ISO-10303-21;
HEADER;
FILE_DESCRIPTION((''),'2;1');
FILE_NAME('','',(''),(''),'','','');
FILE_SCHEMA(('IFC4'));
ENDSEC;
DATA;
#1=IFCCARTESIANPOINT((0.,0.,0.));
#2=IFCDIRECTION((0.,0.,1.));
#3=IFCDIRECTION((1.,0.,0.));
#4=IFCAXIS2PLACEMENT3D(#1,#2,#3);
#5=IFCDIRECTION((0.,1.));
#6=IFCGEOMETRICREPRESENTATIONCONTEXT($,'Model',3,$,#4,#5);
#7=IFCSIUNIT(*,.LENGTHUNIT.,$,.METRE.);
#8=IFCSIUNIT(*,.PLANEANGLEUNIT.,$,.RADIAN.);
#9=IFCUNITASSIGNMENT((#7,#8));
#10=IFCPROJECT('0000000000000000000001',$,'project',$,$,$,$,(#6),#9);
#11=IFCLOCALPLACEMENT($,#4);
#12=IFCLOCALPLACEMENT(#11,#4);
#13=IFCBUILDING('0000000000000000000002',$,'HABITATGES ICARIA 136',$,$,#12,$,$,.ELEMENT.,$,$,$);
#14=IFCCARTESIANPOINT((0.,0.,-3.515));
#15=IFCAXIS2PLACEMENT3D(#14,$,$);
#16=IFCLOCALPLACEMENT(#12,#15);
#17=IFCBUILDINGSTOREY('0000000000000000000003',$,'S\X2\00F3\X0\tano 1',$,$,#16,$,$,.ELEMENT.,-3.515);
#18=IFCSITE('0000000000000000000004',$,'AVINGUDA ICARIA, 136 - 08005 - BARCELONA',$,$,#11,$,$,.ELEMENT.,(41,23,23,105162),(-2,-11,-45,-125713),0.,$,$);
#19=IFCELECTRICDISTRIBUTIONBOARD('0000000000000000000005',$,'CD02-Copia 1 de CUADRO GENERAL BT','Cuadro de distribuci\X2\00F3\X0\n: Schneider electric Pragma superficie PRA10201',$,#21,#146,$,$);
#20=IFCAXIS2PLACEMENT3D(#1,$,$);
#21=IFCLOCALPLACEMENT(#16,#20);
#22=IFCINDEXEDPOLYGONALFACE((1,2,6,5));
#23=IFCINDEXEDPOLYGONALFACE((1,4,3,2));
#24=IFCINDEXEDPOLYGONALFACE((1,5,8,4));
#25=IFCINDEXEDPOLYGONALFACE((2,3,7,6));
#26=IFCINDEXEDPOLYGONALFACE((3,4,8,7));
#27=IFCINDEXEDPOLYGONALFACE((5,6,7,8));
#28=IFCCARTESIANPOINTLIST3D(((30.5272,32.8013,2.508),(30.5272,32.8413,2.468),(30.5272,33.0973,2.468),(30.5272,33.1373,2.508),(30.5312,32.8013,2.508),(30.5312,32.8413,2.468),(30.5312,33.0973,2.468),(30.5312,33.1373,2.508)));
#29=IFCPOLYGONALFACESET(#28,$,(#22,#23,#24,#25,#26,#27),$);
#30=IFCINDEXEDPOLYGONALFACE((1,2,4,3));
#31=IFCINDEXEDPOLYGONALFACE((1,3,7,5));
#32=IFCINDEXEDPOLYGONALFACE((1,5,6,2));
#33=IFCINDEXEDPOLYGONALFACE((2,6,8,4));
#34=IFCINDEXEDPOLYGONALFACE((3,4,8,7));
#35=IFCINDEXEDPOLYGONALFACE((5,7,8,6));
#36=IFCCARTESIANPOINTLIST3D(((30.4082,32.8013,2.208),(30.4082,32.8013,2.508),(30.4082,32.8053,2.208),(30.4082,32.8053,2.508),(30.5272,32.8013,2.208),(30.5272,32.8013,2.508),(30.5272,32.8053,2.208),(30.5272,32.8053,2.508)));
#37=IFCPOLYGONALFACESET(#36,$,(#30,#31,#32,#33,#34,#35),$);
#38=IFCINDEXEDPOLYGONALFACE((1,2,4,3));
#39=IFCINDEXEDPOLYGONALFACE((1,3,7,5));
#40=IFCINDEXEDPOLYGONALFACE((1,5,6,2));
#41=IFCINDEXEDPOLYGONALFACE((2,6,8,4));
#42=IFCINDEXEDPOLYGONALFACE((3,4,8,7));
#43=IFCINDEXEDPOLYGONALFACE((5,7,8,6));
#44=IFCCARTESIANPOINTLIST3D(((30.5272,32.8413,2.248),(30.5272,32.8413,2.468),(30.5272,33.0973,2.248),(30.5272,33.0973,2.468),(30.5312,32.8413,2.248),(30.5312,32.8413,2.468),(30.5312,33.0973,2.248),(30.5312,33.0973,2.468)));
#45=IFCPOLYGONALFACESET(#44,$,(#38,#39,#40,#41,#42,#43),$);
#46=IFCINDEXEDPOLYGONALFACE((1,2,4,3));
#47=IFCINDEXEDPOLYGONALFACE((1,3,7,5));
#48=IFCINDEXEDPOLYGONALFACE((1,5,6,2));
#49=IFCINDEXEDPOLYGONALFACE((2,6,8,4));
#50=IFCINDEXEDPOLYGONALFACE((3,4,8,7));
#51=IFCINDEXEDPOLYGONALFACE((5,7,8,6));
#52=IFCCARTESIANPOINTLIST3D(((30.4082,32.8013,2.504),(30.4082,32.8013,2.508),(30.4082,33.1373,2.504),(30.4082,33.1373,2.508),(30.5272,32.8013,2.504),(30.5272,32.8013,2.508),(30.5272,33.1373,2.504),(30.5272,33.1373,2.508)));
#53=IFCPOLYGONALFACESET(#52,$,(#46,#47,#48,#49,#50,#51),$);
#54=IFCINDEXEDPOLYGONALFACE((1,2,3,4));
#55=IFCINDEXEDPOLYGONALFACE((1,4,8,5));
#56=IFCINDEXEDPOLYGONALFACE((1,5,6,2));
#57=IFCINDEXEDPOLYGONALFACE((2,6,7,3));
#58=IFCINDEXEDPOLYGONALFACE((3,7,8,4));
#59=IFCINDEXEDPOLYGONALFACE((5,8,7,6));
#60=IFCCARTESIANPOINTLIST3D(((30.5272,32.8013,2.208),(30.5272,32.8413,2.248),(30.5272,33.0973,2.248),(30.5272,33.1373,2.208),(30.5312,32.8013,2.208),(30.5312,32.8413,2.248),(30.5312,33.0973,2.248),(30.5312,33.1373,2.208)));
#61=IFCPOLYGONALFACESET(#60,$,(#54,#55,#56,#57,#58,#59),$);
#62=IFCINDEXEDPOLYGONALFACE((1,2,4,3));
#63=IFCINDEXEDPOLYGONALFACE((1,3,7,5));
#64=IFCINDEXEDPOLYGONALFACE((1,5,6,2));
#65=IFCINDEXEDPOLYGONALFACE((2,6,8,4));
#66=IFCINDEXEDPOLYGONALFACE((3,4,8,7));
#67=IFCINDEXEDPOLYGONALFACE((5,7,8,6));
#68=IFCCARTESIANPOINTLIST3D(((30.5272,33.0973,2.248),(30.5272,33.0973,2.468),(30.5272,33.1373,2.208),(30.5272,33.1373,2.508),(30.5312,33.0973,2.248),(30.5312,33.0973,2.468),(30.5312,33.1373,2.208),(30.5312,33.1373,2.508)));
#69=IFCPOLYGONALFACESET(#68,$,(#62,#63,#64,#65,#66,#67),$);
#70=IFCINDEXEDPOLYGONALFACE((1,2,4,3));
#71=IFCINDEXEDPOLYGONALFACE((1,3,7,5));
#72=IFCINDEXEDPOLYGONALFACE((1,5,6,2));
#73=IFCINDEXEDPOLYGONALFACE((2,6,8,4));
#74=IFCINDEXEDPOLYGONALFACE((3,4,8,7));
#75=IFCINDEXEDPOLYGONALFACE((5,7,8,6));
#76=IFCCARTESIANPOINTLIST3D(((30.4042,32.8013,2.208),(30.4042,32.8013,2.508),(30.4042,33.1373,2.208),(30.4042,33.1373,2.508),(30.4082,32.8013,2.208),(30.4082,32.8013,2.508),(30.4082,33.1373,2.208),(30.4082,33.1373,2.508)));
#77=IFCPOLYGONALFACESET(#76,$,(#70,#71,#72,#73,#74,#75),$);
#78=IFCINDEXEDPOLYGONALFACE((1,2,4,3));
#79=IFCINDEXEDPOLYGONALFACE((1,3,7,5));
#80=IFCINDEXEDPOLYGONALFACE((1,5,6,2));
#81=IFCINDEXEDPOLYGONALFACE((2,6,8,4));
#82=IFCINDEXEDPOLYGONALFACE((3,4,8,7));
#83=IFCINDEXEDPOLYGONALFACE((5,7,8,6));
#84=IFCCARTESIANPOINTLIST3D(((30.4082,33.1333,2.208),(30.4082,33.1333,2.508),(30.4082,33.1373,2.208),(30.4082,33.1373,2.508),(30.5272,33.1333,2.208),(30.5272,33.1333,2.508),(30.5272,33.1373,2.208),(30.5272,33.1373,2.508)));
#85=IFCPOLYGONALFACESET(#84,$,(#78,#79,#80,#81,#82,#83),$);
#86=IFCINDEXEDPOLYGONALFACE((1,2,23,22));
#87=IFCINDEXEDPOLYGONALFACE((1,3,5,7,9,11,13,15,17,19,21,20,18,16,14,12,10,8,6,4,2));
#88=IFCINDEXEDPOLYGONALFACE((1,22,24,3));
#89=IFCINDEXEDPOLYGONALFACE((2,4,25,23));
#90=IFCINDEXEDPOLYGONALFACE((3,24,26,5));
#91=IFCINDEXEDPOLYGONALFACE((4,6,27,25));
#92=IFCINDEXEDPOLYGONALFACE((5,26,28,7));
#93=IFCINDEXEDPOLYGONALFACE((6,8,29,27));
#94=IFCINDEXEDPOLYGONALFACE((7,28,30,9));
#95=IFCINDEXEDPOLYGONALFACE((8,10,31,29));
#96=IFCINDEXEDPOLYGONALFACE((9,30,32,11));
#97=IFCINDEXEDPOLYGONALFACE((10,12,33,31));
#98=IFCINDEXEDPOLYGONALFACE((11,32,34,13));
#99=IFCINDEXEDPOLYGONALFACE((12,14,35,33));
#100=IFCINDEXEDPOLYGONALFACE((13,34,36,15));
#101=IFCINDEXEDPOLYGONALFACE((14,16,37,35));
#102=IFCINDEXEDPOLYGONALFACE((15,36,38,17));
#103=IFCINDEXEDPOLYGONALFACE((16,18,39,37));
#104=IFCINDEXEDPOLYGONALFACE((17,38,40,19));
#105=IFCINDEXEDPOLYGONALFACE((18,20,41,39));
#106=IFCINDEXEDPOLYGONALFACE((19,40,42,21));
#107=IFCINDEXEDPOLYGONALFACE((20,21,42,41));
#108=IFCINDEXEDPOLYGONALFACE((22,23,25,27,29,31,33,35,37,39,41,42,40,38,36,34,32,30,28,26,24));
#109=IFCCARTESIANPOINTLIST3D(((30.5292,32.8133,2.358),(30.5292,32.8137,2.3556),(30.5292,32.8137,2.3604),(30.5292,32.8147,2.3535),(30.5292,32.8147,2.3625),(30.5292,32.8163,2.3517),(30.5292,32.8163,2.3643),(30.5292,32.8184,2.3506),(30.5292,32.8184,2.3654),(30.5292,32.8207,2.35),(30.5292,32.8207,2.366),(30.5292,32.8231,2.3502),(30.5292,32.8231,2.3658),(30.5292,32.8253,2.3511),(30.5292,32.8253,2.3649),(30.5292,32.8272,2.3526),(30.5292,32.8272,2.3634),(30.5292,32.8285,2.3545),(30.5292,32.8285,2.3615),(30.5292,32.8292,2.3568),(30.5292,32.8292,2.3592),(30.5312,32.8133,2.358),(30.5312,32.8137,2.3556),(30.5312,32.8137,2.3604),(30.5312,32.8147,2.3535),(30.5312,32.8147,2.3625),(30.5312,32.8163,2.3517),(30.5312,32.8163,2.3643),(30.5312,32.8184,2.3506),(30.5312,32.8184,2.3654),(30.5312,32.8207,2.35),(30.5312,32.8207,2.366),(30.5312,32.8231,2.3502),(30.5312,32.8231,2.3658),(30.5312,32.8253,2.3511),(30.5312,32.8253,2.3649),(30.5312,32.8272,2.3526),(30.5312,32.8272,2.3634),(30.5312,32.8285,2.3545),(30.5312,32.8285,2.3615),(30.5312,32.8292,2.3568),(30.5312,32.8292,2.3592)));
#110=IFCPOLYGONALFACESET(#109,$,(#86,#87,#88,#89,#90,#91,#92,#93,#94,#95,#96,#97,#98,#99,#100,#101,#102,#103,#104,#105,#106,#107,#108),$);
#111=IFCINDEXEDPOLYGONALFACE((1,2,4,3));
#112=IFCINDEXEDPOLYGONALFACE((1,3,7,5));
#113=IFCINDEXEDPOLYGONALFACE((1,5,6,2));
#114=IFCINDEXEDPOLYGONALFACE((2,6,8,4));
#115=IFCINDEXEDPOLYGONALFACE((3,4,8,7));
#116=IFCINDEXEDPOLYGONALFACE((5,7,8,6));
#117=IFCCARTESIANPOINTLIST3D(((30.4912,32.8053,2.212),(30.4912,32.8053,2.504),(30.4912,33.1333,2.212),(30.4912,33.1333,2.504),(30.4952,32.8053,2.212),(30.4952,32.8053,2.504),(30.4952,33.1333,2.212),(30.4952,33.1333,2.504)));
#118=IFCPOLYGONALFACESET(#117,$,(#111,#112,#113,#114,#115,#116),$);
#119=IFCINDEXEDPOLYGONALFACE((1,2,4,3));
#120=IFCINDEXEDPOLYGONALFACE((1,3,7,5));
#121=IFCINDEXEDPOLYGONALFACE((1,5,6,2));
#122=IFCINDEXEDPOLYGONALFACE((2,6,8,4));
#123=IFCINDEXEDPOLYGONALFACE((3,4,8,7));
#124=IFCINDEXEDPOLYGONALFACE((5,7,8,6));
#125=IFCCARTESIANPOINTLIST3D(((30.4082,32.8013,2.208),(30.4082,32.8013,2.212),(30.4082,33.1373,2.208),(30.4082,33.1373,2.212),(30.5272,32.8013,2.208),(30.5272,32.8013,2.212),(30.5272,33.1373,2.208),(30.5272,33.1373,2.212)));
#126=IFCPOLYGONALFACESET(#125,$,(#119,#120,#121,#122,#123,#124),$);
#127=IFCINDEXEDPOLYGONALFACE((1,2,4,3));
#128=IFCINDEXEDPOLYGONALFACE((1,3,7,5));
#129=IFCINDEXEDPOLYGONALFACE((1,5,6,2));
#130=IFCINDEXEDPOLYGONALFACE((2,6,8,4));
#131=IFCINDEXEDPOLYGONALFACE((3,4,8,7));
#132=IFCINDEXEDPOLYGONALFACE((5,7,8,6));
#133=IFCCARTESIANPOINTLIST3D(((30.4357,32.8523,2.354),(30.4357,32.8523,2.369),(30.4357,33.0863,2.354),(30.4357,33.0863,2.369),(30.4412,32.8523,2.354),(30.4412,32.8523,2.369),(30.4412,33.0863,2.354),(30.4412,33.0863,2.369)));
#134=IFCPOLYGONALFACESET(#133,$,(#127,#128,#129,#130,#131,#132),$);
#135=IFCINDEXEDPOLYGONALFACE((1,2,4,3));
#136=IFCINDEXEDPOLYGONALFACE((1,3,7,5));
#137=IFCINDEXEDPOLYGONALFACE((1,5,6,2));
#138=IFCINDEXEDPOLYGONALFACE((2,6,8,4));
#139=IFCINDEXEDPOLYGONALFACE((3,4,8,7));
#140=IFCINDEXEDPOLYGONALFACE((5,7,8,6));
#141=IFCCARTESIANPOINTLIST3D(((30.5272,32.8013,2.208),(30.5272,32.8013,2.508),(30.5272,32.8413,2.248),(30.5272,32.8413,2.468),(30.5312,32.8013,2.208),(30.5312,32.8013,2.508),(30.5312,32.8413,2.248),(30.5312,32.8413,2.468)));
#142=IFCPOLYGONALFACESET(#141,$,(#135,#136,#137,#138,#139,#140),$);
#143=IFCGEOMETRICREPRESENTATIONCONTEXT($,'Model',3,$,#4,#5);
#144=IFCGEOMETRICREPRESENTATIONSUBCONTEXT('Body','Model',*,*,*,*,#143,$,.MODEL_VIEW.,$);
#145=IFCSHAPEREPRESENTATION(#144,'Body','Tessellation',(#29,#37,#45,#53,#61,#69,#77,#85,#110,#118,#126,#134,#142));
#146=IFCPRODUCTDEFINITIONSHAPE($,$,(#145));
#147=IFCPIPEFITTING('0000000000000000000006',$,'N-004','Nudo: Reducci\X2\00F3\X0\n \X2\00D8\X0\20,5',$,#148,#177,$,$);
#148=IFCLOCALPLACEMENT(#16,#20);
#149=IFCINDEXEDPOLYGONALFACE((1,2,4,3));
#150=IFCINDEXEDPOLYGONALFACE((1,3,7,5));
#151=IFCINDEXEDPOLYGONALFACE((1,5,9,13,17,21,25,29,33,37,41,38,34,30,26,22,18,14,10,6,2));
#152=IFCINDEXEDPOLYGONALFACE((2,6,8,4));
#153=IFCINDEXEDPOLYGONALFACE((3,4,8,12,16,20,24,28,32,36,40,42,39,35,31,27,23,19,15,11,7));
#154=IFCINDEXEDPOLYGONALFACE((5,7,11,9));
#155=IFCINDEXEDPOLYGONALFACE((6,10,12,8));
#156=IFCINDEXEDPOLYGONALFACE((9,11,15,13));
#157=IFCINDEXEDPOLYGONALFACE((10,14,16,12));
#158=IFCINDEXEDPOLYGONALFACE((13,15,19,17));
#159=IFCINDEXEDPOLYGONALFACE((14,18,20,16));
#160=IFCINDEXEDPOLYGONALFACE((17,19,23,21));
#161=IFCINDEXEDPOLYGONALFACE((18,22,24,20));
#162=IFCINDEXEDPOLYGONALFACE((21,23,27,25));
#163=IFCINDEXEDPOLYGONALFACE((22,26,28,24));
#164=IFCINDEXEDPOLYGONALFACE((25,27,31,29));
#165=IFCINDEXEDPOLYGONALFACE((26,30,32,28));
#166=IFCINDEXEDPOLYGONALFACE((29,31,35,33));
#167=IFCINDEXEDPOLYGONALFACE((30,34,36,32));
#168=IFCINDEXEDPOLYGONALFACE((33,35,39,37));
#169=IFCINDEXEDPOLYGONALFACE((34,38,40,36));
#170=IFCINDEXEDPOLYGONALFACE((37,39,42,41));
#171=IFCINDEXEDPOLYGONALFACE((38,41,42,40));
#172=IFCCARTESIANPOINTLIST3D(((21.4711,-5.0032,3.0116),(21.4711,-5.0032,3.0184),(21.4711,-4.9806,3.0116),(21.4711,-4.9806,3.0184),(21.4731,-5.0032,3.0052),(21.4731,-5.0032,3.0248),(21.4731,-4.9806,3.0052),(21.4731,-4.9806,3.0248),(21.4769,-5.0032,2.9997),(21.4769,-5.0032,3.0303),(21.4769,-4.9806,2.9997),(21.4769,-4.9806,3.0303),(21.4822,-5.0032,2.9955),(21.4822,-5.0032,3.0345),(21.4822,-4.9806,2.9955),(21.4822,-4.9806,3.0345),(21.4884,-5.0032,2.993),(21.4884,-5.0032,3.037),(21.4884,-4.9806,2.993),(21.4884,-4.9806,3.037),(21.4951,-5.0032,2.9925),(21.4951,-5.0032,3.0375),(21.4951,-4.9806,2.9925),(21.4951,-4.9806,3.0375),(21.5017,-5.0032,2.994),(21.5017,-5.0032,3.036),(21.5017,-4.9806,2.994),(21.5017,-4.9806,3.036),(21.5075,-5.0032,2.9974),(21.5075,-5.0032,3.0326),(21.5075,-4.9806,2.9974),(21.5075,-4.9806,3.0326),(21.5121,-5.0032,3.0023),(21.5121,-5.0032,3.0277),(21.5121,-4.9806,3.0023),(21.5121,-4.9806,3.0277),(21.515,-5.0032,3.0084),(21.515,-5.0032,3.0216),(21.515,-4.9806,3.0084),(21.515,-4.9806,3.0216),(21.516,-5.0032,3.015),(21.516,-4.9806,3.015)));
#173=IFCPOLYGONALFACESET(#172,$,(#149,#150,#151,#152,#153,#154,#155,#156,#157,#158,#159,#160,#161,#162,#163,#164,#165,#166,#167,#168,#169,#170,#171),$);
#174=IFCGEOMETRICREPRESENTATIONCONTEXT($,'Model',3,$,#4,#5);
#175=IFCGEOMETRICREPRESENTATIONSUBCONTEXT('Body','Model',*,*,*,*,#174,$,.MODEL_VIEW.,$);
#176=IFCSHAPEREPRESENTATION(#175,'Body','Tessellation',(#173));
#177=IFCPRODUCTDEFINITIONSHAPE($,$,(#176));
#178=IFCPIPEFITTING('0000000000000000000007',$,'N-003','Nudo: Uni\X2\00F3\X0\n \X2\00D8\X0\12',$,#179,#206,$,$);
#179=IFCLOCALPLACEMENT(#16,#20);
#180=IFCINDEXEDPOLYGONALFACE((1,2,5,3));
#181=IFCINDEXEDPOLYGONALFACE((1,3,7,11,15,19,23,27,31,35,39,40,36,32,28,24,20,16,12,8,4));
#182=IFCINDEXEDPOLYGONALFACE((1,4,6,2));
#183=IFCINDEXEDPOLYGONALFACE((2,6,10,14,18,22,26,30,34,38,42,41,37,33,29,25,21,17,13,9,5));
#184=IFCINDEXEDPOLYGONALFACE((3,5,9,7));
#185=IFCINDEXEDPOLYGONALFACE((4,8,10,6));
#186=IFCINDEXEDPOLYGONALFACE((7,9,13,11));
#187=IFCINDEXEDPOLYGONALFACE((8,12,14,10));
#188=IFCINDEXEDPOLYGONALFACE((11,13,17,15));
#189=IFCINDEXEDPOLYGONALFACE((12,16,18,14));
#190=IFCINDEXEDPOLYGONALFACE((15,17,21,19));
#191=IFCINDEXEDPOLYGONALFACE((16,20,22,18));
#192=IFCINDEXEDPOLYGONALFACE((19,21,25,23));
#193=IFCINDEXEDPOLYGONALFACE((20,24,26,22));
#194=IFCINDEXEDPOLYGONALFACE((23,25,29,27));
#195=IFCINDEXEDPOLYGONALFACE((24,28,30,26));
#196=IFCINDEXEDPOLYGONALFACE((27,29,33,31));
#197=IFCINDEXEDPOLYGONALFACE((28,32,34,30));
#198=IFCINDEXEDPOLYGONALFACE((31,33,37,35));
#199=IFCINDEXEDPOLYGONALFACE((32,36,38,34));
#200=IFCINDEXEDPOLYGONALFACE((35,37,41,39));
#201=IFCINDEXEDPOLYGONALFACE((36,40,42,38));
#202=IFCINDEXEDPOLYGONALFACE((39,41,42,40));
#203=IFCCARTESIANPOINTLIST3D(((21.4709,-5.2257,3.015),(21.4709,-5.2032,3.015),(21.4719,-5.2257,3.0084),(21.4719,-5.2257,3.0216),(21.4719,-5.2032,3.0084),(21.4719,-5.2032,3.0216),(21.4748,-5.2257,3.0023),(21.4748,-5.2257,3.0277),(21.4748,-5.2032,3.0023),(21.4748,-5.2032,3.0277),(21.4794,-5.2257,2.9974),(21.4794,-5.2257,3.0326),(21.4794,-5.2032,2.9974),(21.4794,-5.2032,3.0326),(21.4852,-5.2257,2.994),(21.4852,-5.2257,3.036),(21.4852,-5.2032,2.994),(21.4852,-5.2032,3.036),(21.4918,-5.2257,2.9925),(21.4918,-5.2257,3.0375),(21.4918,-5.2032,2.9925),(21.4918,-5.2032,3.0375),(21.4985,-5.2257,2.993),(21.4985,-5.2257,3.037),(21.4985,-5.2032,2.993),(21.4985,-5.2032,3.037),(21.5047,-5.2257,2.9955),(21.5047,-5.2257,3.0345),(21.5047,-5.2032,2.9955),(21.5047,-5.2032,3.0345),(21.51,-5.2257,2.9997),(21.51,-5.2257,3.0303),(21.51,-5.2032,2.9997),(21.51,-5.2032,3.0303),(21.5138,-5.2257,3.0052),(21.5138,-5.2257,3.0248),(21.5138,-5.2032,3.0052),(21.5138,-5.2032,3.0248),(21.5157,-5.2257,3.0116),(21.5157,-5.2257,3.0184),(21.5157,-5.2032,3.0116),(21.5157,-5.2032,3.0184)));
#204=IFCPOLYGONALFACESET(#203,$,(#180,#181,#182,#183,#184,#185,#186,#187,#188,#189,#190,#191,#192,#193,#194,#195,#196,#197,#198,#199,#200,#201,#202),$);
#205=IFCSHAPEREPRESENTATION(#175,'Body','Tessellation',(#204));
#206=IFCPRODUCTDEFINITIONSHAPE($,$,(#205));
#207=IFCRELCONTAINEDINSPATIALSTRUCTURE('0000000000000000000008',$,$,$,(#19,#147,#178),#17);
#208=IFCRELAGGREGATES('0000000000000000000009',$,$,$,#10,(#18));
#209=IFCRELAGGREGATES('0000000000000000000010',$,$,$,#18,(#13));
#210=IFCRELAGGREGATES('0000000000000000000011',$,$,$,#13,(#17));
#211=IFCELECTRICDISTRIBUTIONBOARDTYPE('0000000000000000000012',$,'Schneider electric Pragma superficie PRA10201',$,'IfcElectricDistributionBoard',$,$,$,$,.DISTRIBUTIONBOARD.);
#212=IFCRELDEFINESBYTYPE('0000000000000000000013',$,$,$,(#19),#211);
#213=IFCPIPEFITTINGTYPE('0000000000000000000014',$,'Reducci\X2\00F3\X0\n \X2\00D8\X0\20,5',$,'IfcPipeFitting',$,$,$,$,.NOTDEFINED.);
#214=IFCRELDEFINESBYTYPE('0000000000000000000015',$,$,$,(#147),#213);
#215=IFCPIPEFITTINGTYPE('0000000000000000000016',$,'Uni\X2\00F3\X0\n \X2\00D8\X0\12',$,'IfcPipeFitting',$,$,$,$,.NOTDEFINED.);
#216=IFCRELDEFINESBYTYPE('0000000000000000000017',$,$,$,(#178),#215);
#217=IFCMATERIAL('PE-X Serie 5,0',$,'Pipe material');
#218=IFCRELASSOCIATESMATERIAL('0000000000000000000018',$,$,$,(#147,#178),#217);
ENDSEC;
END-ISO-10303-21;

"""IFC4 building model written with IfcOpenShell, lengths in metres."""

from ifc_helpers import new_model, si_unit, direction, frame, origin_with_axes, origin_2d_with_axis, place, context, subcontext, project, spatial, polyline, circle, outline, extrude, source, transform, mapped, material, type_object, element, save


model = new_model("IFC4")

# Units and contexts
model_context_1 = context("Model", 3, world=origin_with_axes(), true_north=direction((0.0, 1.0)))
model_context_2 = context("Model", 3, world=origin_with_axes(), true_north=direction((0.0, 1.0)))
model_context_3 = context("Model", 3, world=origin_with_axes(), true_north=direction((0.0, 1.0)))
body_context_1 = subcontext(model_context_2, "Body", "Model", "MODEL_VIEW")
body_context_2 = subcontext(model_context_3, "Body", "Model", "MODEL_VIEW")
ifc_project = project(units=[si_unit("LENGTHUNIT", "METRE"), si_unit("PLANEANGLEUNIT", "RADIAN")], contexts=[model_context_1])

# Site, building, storey
site_placement = place(None, origin_with_axes())
site = spatial("IfcSite", under=ifc_project, at=site_placement, Name="AVINGUDA ICARIA, 136 - 08005 - BARCELONA", CompositionType="ELEMENT", RefLatitude=(41, 23, 23, 105162), RefLongitude=(-2, -11, -45, -125713), RefElevation=0.0)
building_placement = place(site_placement, origin_with_axes())
building = spatial("IfcBuilding", under=site, at=building_placement, Name="HABITATGES ICARIA 136", CompositionType="ELEMENT")
storey_placement = place(building_placement, frame((0.0, 0.0, -3.515)))
storey = spatial("IfcBuildingStorey", under=building, at=storey_placement, Name="Sótano 1", CompositionType="ELEMENT", Elevation=-3.515)

# Shared definitions
placement_1 = place(None, origin_with_axes())
placement_2 = place(placement_1, origin_with_axes())
placement_3 = place(placement_2, frame((0.0, 0.0, -3.515)))

# Electric distribution board
electric_distribution_board_type = type_object("IfcElectricDistributionBoardType", Name="Schneider electric Pragma superficie PRA10201", ApplicableOccurrence="IfcElectricDistributionBoard", PredefinedType="DISTRIBUTIONBOARD")
shared_shape_1 = source(origin_with_axes(), body_context_1, "Body", "SweptSolid", [
    extrude(outline(polyline([(-0.168, 0.3), (0.168, 0.3), (0.128, 0.26), (-0.128, 0.26), (-0.168, 0.3)])), frame((0.0, -0.127, 0.0), z_axis=(0.0, 1.0, 0.0), x_axis=(-1.0, 0.0, 0.0)), (0.0, 0.0, 1.0), 0.004),
    extrude(outline(polyline([(-0.168, -0.004), (-0.164, -0.004), (-0.164, -0.123), (-0.168, -0.123), (-0.168, -0.004)])), origin_with_axes(), (0.0, 0.0, 1.0), 0.3),
    extrude(outline(polyline([(-0.128, -0.127), (0.128, -0.127), (0.128, -0.123), (-0.128, -0.123), (-0.128, -0.127)])), frame((0.0, 0.0, 0.04), z_axis=(0.0, 0.0, 1.0), x_axis=(1.0, 0.0, 0.0)), (0.0, 0.0, 1.0), 0.22),
    extrude(outline(polyline([(-0.168, -0.004), (0.168, -0.004), (0.168, -0.123), (-0.168, -0.123), (-0.168, -0.004)])), frame((0.0, 0.0, 0.296), z_axis=(0.0, 0.0, 1.0), x_axis=(1.0, 0.0, 0.0)), (0.0, 0.0, 1.0), 0.004),
    extrude(outline(polyline([(-0.168, 0.0), (0.168, 0.0), (0.128, 0.04), (-0.128, 0.04), (-0.168, 0.0)])), frame((0.0, -0.127, 0.0), z_axis=(0.0, 1.0, 0.0), x_axis=(-1.0, 0.0, 0.0)), (0.0, 0.0, 1.0), 0.004),
    extrude(outline(polyline([(-0.168, 0.0), (-0.128, 0.04), (-0.128, 0.26), (-0.168, 0.3), (-0.168, 0.0)])), frame((0.0, -0.127, 0.0), z_axis=(0.0, 1.0, 0.0), x_axis=(-1.0, 0.0, 0.0)), (0.0, 0.0, 1.0), 0.004),
    extrude(outline(polyline([(-0.168, 0.0), (0.168, 0.0), (0.168, -0.004), (-0.168, -0.004), (-0.168, 0.0)])), origin_with_axes(), (0.0, 0.0, 1.0), 0.3),
    extrude(outline(polyline([(0.164, -0.004), (0.168, -0.004), (0.168, -0.123), (0.164, -0.123), (0.164, -0.004)])), origin_with_axes(), (0.0, 0.0, 1.0), 0.3),
    extrude(circle(Radius=0.008, at=origin_2d_with_axis()), frame((-0.148, -0.127, 0.15), z_axis=(0.0, 1.0, 0.0), x_axis=(-1.0, 0.0, 0.0)), (0.0, 0.0, 1.0), 0.002),
    extrude(outline(polyline([(-0.164, -0.091), (0.164, -0.091), (0.164, -0.087), (-0.164, -0.087), (-0.164, -0.091)])), frame((0.0, 0.0, 0.004), z_axis=(0.0, 0.0, 1.0), x_axis=(1.0, 0.0, 0.0)), (0.0, 0.0, 1.0), 0.292),
    extrude(outline(polyline([(-0.168, -0.004), (0.168, -0.004), (0.168, -0.123), (-0.168, -0.123), (-0.168, -0.004)])), origin_with_axes(), (0.0, 0.0, 1.0), 0.004),
    extrude(outline(polyline([(-0.117, -0.037), (0.117, -0.037), (0.117, -0.0315), (-0.117, -0.0315), (-0.117, -0.037)])), frame((0.0, 0.0, 0.146), z_axis=(0.0, 0.0, 1.0), x_axis=(1.0, 0.0, 0.0)), (0.0, 0.0, 1.0), 0.015),
    extrude(outline(polyline([(0.168, 0.0), (0.128, 0.04), (0.128, 0.26), (0.168, 0.3), (0.168, 0.0)])), frame((0.0, -0.127, 0.0), z_axis=(0.0, 1.0, 0.0), x_axis=(-1.0, 0.0, 0.0)), (0.0, 0.0, 1.0), 0.004),
])
electric_distribution_board_1_placement = place(placement_3, origin_with_axes())
element("IfcElectricDistributionBoard", 1, at=electric_distribution_board_1_placement, inside=storey, type_object=electric_distribution_board_type, Name="CD02-Copia 1 de CUADRO GENERAL BT", Description="Cuadro de distribución: Schneider electric Pragma superficie PRA10201", context=body_context_1, shape_type="MappedRepresentation", body=[
    mapped(shared_shape_1, transform((30.4042, 32.9693, 2.208), x_axis=(0.0, 1.0, 0.0), y_axis=(-1.0, 0.0, 0.0), z_axis=(0.0, 0.0, 1.0), scale=1.0)),
])

# Pipe fittings
ifc_material_1 = material(Name="PE-X Serie 5,0", Category="Pipe material")
pipe_fitting_type_1 = type_object("IfcPipeFittingType", Name="Reducción Ø20,5", ApplicableOccurrence="IfcPipeFitting", PredefinedType="NOTDEFINED")
shared_shape_2 = source(origin_with_axes(), body_context_2, "Body", "SweptSolid", [
    extrude(circle(Radius=0.0226, at=origin_2d_with_axis()), frame((0.0, -0.0226, 0.0), z_axis=(0.0, 1.0, 0.0), x_axis=(-1.0, 0.0, 0.0)), (0.0, 0.0, 1.0), 0.0226),
])
placement_4 = place(None, origin_with_axes())
placement_5 = place(placement_4, origin_with_axes())
placement_6 = place(placement_5, frame((0.0, 0.0, -3.515)))
pipe_fitting_1_placement = place(placement_6, origin_with_axes())
element("IfcPipeFitting", 2, at=pipe_fitting_1_placement, inside=storey, type_object=pipe_fitting_type_1, material=ifc_material_1, Name="N-004", Description="Nudo: Reducción Ø20,5", context=body_context_2, shape_type="MappedRepresentation", body=[
    mapped(shared_shape_2, transform((21.4934, -5.0032, 3.015), x_axis=(-1.0, 0.0, 0.0), y_axis=(0.0, -1.0, 0.0), z_axis=(0.0, 0.0, 1.0), scale=1.0)),
])
pipe_fitting_type_2 = type_object("IfcPipeFittingType", Name="Unión Ø12", ApplicableOccurrence="IfcPipeFitting", PredefinedType="NOTDEFINED")
pipe_fitting_2_placement = place(placement_6, origin_with_axes())
element("IfcPipeFitting", 3, at=pipe_fitting_2_placement, inside=storey, type_object=pipe_fitting_type_2, material=ifc_material_1, Name="N-003", Description="Nudo: Unión Ø12", context=body_context_2, shape_type="MappedRepresentation", body=[
    mapped(shared_shape_2, transform((21.4934, -5.2032, 3.015), x_axis=(1.0, 0.0, 0.0), y_axis=(0.0, 1.0, 0.0), z_axis=(0.0, 0.0, 1.0), scale=1.0)),
])

save(model, "model.ifc")
